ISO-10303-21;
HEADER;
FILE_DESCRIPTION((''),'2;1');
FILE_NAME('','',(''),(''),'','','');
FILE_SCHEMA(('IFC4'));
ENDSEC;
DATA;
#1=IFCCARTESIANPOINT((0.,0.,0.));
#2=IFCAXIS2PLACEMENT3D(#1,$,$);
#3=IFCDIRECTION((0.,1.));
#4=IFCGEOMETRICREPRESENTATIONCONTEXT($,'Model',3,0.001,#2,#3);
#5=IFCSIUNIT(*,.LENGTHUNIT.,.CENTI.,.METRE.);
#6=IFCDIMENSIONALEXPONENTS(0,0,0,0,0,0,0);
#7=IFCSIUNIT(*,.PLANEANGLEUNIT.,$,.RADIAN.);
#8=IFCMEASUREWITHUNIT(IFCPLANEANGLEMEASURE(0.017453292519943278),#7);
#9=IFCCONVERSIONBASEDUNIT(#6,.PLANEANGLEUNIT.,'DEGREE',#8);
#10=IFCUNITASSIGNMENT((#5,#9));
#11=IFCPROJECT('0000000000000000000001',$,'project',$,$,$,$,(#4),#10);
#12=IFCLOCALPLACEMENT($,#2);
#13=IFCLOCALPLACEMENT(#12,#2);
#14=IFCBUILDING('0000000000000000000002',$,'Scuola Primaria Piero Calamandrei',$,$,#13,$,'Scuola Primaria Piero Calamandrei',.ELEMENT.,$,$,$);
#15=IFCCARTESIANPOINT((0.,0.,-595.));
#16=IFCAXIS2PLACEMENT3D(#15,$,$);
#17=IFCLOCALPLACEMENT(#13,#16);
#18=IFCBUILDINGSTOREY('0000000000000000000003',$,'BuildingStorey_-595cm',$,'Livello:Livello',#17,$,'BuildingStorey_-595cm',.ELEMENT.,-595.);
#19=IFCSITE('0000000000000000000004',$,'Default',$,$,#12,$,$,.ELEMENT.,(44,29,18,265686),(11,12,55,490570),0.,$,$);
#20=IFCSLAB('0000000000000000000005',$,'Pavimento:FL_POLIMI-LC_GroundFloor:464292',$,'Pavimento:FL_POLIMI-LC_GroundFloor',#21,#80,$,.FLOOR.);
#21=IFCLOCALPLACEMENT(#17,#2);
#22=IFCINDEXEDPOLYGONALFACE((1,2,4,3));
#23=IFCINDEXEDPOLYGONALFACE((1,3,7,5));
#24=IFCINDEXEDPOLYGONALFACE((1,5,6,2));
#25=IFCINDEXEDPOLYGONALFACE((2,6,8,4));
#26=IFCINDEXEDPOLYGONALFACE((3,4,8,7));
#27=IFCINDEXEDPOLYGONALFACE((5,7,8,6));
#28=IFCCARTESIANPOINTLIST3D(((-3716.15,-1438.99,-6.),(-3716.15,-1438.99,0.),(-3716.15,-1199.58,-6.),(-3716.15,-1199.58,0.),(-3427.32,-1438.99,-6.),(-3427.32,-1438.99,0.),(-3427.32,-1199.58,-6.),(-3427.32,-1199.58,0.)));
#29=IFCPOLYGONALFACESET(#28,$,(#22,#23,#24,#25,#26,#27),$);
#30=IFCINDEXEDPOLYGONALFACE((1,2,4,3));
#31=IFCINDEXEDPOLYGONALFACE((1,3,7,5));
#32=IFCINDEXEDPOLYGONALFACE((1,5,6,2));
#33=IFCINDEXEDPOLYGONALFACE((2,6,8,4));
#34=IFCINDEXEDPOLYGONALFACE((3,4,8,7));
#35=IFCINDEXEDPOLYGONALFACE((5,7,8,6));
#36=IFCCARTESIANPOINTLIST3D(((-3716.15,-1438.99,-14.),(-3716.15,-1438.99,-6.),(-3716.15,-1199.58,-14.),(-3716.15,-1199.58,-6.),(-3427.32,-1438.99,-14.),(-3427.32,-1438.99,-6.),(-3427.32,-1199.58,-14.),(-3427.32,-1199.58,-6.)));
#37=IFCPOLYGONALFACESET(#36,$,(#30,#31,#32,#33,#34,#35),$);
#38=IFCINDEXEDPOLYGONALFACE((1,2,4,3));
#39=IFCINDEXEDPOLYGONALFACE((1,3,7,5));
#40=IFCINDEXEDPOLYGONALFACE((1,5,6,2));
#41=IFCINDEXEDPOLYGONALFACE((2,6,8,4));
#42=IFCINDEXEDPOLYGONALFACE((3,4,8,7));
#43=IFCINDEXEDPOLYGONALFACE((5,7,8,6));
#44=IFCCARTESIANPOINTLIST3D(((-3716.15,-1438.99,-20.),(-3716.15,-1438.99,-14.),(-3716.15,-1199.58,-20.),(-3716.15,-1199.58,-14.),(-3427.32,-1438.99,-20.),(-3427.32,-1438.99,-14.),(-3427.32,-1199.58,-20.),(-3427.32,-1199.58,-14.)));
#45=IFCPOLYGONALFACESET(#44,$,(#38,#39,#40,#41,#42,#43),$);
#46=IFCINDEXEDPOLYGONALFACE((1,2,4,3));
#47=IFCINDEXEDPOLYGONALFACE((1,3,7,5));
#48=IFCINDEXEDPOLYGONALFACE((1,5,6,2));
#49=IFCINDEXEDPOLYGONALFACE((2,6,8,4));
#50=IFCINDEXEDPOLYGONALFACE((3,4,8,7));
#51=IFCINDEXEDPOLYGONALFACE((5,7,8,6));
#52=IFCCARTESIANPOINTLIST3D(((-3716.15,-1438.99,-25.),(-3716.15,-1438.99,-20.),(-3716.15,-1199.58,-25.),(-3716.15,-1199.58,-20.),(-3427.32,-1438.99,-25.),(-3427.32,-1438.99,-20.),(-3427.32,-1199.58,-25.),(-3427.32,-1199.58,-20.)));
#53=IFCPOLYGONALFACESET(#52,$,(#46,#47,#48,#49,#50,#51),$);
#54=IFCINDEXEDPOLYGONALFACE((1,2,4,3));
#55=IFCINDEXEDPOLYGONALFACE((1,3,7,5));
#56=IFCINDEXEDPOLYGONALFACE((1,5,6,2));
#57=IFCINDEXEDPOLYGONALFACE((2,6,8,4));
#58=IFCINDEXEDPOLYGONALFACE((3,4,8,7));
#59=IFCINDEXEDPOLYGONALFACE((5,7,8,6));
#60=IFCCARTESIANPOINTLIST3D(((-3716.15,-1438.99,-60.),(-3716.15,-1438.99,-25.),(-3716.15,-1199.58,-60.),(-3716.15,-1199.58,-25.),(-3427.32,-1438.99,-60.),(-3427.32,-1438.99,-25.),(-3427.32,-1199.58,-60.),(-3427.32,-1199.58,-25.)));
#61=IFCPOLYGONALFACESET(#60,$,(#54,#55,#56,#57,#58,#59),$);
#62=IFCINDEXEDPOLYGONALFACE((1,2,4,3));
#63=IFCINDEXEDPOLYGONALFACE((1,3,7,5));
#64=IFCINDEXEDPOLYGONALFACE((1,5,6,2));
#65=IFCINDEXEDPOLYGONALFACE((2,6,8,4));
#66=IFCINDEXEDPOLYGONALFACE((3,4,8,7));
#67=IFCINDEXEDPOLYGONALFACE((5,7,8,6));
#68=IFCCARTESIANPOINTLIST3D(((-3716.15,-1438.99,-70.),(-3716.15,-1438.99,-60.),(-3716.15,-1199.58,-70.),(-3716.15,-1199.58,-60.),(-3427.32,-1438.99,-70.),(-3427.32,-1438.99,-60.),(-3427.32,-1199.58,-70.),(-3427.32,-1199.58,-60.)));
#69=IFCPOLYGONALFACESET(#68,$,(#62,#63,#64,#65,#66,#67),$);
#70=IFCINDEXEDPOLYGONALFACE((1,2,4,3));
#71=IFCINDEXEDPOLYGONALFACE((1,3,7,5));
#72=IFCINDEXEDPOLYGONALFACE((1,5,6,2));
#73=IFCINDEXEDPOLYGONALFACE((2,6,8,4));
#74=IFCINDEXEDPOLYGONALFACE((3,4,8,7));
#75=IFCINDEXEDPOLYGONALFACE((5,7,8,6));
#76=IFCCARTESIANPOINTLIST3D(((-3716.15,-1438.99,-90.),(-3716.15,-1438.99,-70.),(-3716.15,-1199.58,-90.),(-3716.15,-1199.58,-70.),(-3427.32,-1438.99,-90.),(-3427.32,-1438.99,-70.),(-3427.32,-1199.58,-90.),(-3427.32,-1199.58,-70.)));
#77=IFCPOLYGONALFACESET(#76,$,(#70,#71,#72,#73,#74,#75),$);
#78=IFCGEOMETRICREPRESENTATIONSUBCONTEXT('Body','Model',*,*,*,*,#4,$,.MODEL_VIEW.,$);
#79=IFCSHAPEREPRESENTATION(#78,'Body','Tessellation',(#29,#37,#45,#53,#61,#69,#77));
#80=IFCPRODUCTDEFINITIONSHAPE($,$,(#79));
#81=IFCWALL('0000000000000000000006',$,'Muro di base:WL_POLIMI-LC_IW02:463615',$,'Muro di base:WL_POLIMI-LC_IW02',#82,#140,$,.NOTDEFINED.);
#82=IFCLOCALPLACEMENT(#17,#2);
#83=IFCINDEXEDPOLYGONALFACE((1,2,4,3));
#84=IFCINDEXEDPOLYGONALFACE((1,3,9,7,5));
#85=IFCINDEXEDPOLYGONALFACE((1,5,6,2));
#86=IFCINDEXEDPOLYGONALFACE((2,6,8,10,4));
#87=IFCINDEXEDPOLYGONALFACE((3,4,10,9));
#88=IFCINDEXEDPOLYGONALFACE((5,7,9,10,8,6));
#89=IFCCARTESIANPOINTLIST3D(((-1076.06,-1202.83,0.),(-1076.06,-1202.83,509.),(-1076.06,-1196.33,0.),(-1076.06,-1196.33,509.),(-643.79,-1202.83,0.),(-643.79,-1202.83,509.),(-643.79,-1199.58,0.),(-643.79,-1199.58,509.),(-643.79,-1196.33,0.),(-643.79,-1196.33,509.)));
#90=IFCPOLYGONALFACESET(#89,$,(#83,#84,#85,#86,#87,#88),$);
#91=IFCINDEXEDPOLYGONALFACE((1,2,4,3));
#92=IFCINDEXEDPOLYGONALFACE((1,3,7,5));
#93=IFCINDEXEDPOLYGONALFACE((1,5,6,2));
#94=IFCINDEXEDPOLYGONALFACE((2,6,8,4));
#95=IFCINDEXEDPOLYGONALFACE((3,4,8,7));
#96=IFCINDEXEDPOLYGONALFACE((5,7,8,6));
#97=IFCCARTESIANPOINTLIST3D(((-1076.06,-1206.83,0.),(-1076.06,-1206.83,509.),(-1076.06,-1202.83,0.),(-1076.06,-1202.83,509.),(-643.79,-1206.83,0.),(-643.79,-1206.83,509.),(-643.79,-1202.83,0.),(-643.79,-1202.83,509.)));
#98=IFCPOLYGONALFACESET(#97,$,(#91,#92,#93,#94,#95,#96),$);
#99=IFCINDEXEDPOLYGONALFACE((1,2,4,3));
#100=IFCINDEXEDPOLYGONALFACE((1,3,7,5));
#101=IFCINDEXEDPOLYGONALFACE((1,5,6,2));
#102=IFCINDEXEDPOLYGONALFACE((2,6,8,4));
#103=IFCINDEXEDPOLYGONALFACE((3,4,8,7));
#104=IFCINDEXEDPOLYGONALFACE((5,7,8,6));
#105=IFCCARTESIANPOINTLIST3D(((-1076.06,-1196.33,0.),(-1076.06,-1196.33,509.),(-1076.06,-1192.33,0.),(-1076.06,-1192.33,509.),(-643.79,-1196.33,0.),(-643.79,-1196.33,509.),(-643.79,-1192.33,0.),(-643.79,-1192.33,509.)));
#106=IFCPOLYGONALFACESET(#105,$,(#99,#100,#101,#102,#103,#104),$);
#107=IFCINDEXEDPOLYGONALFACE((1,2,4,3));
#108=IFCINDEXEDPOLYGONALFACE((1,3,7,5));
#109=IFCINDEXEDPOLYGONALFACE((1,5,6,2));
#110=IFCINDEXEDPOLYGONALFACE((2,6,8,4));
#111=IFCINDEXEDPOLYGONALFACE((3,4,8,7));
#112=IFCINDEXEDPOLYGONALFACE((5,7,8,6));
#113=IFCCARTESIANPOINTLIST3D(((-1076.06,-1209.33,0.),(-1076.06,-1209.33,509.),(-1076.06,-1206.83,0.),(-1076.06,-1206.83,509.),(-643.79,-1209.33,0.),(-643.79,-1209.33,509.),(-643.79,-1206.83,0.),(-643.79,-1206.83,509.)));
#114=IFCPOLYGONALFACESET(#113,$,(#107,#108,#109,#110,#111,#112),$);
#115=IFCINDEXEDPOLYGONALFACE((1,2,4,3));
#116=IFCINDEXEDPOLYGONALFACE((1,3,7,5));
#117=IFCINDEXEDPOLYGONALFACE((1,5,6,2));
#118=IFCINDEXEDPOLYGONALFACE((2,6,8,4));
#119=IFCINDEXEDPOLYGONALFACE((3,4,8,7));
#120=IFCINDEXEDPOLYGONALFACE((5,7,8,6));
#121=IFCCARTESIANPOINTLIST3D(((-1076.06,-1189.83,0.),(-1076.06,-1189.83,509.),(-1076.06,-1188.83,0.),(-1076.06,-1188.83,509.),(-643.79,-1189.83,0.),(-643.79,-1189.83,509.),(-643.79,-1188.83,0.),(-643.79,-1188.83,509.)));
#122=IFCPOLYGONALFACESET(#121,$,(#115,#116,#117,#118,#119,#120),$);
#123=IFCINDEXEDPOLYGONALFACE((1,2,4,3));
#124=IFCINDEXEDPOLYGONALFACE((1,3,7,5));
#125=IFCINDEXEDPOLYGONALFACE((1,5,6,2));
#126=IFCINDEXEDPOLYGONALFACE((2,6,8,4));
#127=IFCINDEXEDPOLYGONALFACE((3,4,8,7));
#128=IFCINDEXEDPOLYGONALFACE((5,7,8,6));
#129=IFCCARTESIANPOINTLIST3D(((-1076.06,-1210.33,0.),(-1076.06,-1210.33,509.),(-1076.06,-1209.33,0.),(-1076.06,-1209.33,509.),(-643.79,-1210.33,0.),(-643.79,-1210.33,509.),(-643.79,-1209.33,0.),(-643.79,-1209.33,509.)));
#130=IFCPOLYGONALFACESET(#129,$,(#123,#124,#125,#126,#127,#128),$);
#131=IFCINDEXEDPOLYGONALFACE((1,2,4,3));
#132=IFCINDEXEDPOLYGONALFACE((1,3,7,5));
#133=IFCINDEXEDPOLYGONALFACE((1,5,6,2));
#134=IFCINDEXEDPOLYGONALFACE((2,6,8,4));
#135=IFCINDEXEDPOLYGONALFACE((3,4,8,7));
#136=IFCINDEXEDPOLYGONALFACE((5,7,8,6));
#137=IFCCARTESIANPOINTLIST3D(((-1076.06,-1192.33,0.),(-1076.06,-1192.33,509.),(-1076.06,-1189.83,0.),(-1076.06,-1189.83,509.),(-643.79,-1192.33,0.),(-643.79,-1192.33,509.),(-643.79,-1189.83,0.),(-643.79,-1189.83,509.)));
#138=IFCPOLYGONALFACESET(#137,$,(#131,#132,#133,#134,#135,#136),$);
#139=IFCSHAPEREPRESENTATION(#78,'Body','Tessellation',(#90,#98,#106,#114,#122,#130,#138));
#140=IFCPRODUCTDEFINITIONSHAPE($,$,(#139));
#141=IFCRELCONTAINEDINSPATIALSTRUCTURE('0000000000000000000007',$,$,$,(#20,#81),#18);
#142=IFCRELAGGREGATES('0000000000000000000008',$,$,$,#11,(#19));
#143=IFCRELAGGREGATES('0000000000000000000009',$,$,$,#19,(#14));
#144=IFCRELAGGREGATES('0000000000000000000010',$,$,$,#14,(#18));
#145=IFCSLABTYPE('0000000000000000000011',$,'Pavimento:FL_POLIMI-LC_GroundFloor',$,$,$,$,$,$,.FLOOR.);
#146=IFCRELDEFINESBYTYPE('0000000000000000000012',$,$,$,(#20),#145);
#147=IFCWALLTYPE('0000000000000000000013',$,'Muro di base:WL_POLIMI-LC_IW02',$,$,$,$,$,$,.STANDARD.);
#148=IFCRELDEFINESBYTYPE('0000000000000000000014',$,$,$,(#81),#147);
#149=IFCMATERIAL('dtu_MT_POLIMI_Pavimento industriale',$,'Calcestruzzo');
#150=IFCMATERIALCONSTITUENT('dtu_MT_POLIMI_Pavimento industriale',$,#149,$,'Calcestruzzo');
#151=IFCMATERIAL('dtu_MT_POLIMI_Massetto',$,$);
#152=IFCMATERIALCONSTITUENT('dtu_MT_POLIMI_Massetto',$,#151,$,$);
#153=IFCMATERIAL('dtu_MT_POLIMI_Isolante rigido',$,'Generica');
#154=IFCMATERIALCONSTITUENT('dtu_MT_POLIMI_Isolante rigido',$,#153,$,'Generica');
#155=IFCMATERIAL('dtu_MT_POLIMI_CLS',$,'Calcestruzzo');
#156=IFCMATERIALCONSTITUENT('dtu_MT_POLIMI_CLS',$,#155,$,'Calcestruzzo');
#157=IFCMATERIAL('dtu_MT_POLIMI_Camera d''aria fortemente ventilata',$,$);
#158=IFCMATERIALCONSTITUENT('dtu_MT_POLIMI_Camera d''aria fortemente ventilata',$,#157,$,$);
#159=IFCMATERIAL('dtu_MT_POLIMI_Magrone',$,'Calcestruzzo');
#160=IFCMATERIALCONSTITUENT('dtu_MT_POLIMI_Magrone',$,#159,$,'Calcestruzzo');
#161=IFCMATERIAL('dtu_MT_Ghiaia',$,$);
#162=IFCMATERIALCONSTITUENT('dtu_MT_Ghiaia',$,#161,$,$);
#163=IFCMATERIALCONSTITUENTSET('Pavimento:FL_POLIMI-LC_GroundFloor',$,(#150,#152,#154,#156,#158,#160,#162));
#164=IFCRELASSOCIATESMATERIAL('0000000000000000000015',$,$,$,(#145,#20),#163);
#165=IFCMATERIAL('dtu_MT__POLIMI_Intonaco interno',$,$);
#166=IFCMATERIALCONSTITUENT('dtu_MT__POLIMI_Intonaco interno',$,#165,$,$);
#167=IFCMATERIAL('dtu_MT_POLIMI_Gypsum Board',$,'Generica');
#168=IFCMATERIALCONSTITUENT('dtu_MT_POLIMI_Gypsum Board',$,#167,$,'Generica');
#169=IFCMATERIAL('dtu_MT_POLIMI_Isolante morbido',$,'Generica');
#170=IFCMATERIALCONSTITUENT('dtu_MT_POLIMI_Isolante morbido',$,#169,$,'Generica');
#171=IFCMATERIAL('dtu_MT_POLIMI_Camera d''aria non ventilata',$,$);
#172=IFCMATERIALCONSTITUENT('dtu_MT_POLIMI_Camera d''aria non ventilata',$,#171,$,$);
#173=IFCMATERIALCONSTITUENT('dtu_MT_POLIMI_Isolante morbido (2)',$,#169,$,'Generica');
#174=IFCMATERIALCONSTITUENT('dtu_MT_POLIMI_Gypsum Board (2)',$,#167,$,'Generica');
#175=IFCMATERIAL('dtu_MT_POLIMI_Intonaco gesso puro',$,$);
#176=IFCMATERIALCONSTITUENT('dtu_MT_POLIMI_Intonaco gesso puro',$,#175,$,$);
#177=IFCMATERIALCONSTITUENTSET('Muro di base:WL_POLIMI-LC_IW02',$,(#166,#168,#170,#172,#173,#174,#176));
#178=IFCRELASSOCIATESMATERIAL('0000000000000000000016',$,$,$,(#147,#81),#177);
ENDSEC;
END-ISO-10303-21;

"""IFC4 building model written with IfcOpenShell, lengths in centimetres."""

from ifc_helpers import new_model, entity, si_unit, converted_unit, direction, frame, origin, place, context, subcontext, project, spatial, indexed_curve, outline, extrude, material, constituent, constituent_set, type_object, element, save


model = new_model("IFC4")

# Units and contexts
model_context = context("Model", 3, precision=0.001, world=origin(), true_north=direction((0.0, 1.0)))
body_context = subcontext(model_context, "Body", "Model", "MODEL_VIEW")
ifc_project = project(units=[si_unit("LENGTHUNIT", "METRE", prefix="CENTI"), converted_unit("PLANEANGLEUNIT", "DEGREE", entity("IfcPlaneAngleMeasure", 0.017453292519943278), si_unit("PLANEANGLEUNIT", "RADIAN"), dimensions=[0, 0, 0, 0, 0, 0, 0])], contexts=[model_context])

# Site, building, storey
site_placement = place(None, origin())
site = spatial("IfcSite", under=ifc_project, at=site_placement, Name="Default", CompositionType="ELEMENT", RefLatitude=(44, 29, 18, 265686), RefLongitude=(11, 12, 55, 490570), RefElevation=0.0)
building_placement = place(site_placement, origin())
building = spatial("IfcBuilding", under=site, at=building_placement, Name="Scuola Primaria Piero Calamandrei", LongName="Scuola Primaria Piero Calamandrei", CompositionType="ELEMENT")
storey_placement = place(building_placement, frame((0.0, 0.0, -595.0)))
storey = spatial("IfcBuildingStorey", under=building, at=storey_placement, Name="BuildingStorey_-595cm", ObjectType="Livello:Livello", LongName="BuildingStorey_-595cm", CompositionType="ELEMENT", Elevation=-595.0)

# Slab
ifc_material_1 = material(Name="dtu_MT_POLIMI_Pavimento industriale", Category="Calcestruzzo")
ifc_constituent_1 = constituent(ifc_material_1, Name="dtu_MT_POLIMI_Pavimento industriale", Category="Calcestruzzo")
ifc_material_2 = material(Name="dtu_MT_POLIMI_Massetto")
ifc_constituent_2 = constituent(ifc_material_2, Name="dtu_MT_POLIMI_Massetto")
ifc_material_3 = material(Name="dtu_MT_POLIMI_Isolante rigido", Category="Generica")
ifc_constituent_3 = constituent(ifc_material_3, Name="dtu_MT_POLIMI_Isolante rigido", Category="Generica")
ifc_material_4 = material(Name="dtu_MT_POLIMI_CLS", Category="Calcestruzzo")
ifc_constituent_4 = constituent(ifc_material_4, Name="dtu_MT_POLIMI_CLS", Category="Calcestruzzo")
ifc_material_5 = material(Name="dtu_MT_POLIMI_Camera d'aria fortemente ventilata")
ifc_constituent_5 = constituent(ifc_material_5, Name="dtu_MT_POLIMI_Camera d'aria fortemente ventilata")
ifc_material_6 = material(Name="dtu_MT_POLIMI_Magrone", Category="Calcestruzzo")
ifc_constituent_6 = constituent(ifc_material_6, Name="dtu_MT_POLIMI_Magrone", Category="Calcestruzzo")
ifc_material_7 = material(Name="dtu_MT_Ghiaia")
ifc_constituent_7 = constituent(ifc_material_7, Name="dtu_MT_Ghiaia")
ifc_constituent_set_1 = constituent_set(constituents=[ifc_constituent_1, ifc_constituent_2, ifc_constituent_3, ifc_constituent_4, ifc_constituent_5, ifc_constituent_6, ifc_constituent_7], Name="Pavimento:FL_POLIMI-LC_GroundFloor")
slab_type = type_object("IfcSlabType", Name="Pavimento:FL_POLIMI-LC_GroundFloor", PredefinedType="FLOOR", material=ifc_constituent_set_1)
slab_1_placement = place(storey_placement, origin())
element("IfcSlab", 1, at=slab_1_placement, inside=storey, type_object=slab_type, material=ifc_constituent_set_1, Name="Pavimento:FL_POLIMI-LC_GroundFloor:464292", ObjectType="Pavimento:FL_POLIMI-LC_GroundFloor", PredefinedType="FLOOR", context=body_context, shape_type="SweptSolid", body=[
    extrude(outline(indexed_curve([(-144.41, -119.71), (144.41, -119.71), (144.41, 119.71), (-144.41, 119.71), (-144.41, -119.71)], self_intersect=False)), frame((-3571.74, -1319.28, -6.0), z_axis=(0.0, 0.0, 1.0), x_axis=(-1.0, 0.0, 0.0)), (0.0, 0.0, 1.0), 6.0),
    extrude(outline(indexed_curve([(-144.41, -119.71), (144.41, -119.71), (144.41, 119.71), (-144.41, 119.71), (-144.41, -119.71)], self_intersect=False)), frame((-3571.74, -1319.28, -14.0), z_axis=(0.0, 0.0, 1.0), x_axis=(-1.0, 0.0, 0.0)), (0.0, 0.0, 1.0), 8.0),
    extrude(outline(indexed_curve([(-144.41, -119.71), (144.41, -119.71), (144.41, 119.71), (-144.41, 119.71), (-144.41, -119.71)], self_intersect=False)), frame((-3571.74, -1319.28, -20.0), z_axis=(0.0, 0.0, 1.0), x_axis=(-1.0, 0.0, 0.0)), (0.0, 0.0, 1.0), 6.0),
    extrude(outline(indexed_curve([(-144.41, -119.71), (144.41, -119.71), (144.41, 119.71), (-144.41, 119.71), (-144.41, -119.71)], self_intersect=False)), frame((-3571.74, -1319.28, -25.0), z_axis=(0.0, 0.0, 1.0), x_axis=(-1.0, 0.0, 0.0)), (0.0, 0.0, 1.0), 5.0),
    extrude(outline(indexed_curve([(-144.41, -119.71), (144.41, -119.71), (144.41, 119.71), (-144.41, 119.71), (-144.41, -119.71)], self_intersect=False)), frame((-3571.74, -1319.28, -60.0), z_axis=(0.0, 0.0, 1.0), x_axis=(-1.0, 0.0, 0.0)), (0.0, 0.0, 1.0), 35.0),
    extrude(outline(indexed_curve([(-144.41, -119.71), (144.41, -119.71), (144.41, 119.71), (-144.41, 119.71), (-144.41, -119.71)], self_intersect=False)), frame((-3571.74, -1319.28, -70.0), z_axis=(0.0, 0.0, 1.0), x_axis=(-1.0, 0.0, 0.0)), (0.0, 0.0, 1.0), 10.0),
    extrude(outline(indexed_curve([(-144.41, -119.71), (144.41, -119.71), (144.41, 119.71), (-144.41, 119.71), (-144.41, -119.71)], self_intersect=False)), frame((-3571.74, -1319.28, -90.0), z_axis=(0.0, 0.0, 1.0), x_axis=(-1.0, 0.0, 0.0)), (0.0, 0.0, 1.0), 20.0),
])

# Wall
ifc_material_8 = material(Name="dtu_MT__POLIMI_Intonaco interno")
ifc_constituent_8 = constituent(ifc_material_8, Name="dtu_MT__POLIMI_Intonaco interno")
ifc_material_9 = material(Name="dtu_MT_POLIMI_Gypsum Board", Category="Generica")
ifc_constituent_9 = constituent(ifc_material_9, Name="dtu_MT_POLIMI_Gypsum Board", Category="Generica")
ifc_material_10 = material(Name="dtu_MT_POLIMI_Isolante morbido", Category="Generica")
ifc_constituent_10 = constituent(ifc_material_10, Name="dtu_MT_POLIMI_Isolante morbido", Category="Generica")
ifc_material_11 = material(Name="dtu_MT_POLIMI_Camera d'aria non ventilata")
ifc_constituent_11 = constituent(ifc_material_11, Name="dtu_MT_POLIMI_Camera d'aria non ventilata")
ifc_constituent_12 = constituent(ifc_material_10, Name="dtu_MT_POLIMI_Isolante morbido (2)", Category="Generica")
ifc_constituent_13 = constituent(ifc_material_9, Name="dtu_MT_POLIMI_Gypsum Board (2)", Category="Generica")
ifc_material_12 = material(Name="dtu_MT_POLIMI_Intonaco gesso puro")
ifc_constituent_14 = constituent(ifc_material_12, Name="dtu_MT_POLIMI_Intonaco gesso puro")
ifc_constituent_set_2 = constituent_set(constituents=[ifc_constituent_8, ifc_constituent_9, ifc_constituent_10, ifc_constituent_11, ifc_constituent_12, ifc_constituent_13, ifc_constituent_14], Name="Muro di base:WL_POLIMI-LC_IW02")
wall_type = type_object("IfcWallType", Name="Muro di base:WL_POLIMI-LC_IW02", PredefinedType="STANDARD", material=ifc_constituent_set_2)
wall_placement = place(storey_placement, frame((-643.79, -1199.58, 0.0), z_axis=(0.0, 0.0, 1.0), x_axis=(-1.0, 0.0, 0.0)))
element("IfcWall", 2, at=wall_placement, inside=storey, type_object=wall_type, material=ifc_constituent_set_2, Name="Muro di base:WL_POLIMI-LC_IW02:463615", ObjectType="Muro di base:WL_POLIMI-LC_IW02", PredefinedType="NOTDEFINED", context=body_context, shape_type="SweptSolid", body=[
    extrude(outline(indexed_curve([(-172.91, -3.25), (259.36, -3.25), (259.36, 3.25), (-172.91, 3.25), (-172.91, 0.0), (-172.91, -3.25)], self_intersect=False)), frame((172.91, 0.0, 0.0)), (0.0, 0.0, 1.0), 509.0),
    extrude(outline(indexed_curve([(-216.14, -2.0), (216.14, -2.0), (216.14, 2.0), (-216.14, 2.0), (-216.14, -2.0)], self_intersect=False)), frame((216.14, 5.25, 0.0)), (0.0, 0.0, 1.0), 509.0),
    extrude(outline(indexed_curve([(-216.14, -2.0), (216.14, -2.0), (216.14, 2.0), (-216.14, 2.0), (-216.14, -2.0)], self_intersect=False)), frame((216.14, -5.25, 0.0)), (0.0, 0.0, 1.0), 509.0),
    extrude(outline(indexed_curve([(-216.14, -1.25), (216.14, -1.25), (216.14, 1.25), (-216.14, 1.25), (-216.14, -1.25)], self_intersect=False)), frame((216.14, 8.5, 0.0)), (0.0, 0.0, 1.0), 509.0),
    extrude(outline(indexed_curve([(-0.5, -216.14), (0.5, -216.14), (0.5, 216.14), (-0.5, 216.14), (-0.5, -216.14)], self_intersect=False)), frame((216.14, -10.25, 0.0), z_axis=(0.0, 0.0, 1.0), x_axis=(0.0, 1.0, 0.0)), (0.0, 0.0, 1.0), 509.0),
    extrude(outline(indexed_curve([(-0.5, -216.14), (0.5, -216.14), (0.5, 216.14), (-0.5, 216.14), (-0.5, -216.14)], self_intersect=False)), frame((216.14, 10.25, 0.0), z_axis=(0.0, 0.0, 1.0), x_axis=(0.0, -1.0, 0.0)), (0.0, 0.0, 1.0), 509.0),
    extrude(outline(indexed_curve([(-216.14, -1.25), (216.14, -1.25), (216.14, 1.25), (-216.14, 1.25), (-216.14, -1.25)], self_intersect=False)), frame((216.14, -8.5, 0.0)), (0.0, 0.0, 1.0), 509.0),
])

save(model, "model.ifc")
